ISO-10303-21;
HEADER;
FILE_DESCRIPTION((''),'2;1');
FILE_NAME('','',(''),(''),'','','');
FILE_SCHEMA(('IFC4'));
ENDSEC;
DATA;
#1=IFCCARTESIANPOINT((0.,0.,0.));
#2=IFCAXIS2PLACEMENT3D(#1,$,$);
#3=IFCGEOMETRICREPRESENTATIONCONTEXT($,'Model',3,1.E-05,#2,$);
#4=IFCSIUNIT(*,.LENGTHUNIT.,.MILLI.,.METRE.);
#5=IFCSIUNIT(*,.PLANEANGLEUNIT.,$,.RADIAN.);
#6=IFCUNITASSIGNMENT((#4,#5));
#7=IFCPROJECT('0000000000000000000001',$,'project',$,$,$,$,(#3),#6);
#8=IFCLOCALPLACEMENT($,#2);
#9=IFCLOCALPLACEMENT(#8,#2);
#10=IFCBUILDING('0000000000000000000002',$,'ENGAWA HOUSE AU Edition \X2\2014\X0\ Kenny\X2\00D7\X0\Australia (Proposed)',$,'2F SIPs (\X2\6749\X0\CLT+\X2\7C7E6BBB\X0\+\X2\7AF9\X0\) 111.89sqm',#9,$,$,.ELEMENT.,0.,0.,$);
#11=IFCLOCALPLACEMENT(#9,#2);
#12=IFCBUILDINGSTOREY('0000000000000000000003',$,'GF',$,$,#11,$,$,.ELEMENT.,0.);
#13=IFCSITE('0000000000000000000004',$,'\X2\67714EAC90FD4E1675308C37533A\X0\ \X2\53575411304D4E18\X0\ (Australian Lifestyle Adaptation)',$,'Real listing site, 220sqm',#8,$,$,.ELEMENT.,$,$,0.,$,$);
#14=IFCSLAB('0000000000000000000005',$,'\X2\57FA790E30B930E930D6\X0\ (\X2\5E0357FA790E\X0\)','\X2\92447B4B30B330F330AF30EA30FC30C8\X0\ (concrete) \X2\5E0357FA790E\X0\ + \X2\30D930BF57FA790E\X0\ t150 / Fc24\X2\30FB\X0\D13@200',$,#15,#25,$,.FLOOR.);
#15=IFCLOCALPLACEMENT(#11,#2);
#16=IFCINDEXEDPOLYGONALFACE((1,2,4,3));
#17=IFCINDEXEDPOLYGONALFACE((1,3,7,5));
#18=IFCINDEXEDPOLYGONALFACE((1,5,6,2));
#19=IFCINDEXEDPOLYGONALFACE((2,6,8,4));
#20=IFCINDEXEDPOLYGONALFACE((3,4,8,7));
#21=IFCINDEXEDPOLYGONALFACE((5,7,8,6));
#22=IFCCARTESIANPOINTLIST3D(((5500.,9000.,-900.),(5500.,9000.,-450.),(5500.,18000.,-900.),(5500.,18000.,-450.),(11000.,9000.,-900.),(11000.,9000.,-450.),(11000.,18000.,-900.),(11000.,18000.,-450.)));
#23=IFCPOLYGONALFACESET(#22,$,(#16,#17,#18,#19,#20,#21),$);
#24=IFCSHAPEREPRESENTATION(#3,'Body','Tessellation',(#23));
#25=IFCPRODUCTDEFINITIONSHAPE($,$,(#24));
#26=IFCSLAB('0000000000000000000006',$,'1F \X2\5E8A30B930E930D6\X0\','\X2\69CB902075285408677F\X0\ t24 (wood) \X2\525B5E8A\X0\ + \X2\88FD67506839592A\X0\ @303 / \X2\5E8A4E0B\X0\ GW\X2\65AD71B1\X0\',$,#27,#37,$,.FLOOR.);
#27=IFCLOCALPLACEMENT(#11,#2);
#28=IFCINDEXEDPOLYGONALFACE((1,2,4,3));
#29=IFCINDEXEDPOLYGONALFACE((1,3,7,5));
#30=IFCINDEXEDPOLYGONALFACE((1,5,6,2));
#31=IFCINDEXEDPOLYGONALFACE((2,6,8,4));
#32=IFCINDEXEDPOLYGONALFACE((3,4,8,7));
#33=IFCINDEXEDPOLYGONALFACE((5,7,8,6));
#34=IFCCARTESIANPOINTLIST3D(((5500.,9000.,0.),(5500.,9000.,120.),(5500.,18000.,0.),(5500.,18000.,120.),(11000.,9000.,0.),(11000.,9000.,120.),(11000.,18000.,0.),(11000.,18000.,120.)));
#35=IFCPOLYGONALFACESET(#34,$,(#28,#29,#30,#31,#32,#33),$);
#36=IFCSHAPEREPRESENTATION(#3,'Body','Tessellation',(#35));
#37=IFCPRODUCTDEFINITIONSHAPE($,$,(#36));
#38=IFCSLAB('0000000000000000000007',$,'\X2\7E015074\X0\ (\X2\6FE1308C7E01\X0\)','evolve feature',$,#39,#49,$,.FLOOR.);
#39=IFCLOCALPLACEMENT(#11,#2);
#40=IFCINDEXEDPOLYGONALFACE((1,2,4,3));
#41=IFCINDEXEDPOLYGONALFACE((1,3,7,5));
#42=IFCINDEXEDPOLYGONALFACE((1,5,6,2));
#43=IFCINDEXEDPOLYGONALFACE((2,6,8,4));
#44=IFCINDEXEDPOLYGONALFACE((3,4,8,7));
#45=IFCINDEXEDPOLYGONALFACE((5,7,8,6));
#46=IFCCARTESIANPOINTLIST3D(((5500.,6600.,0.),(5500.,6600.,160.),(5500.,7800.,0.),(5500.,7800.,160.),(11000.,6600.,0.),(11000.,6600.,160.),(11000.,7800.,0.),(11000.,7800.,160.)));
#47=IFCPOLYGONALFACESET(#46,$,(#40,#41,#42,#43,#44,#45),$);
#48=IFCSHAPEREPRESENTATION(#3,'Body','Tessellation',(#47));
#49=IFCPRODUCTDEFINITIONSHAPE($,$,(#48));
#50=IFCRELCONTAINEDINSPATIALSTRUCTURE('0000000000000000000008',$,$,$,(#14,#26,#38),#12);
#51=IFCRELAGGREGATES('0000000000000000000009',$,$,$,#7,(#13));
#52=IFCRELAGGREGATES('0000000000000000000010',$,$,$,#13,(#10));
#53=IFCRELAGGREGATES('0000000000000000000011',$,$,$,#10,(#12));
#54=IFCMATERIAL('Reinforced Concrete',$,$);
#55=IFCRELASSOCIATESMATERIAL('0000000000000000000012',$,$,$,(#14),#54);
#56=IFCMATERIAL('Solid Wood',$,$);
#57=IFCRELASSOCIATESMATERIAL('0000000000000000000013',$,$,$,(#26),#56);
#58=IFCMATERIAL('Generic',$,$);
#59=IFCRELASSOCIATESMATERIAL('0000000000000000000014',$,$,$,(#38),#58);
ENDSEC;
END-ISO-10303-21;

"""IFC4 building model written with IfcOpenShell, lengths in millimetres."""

from ifc_helpers import new_model, si_unit, frame, frame_2d, origin, place, context, project, spatial, rectangle, extrude, material, element, save


model = new_model("IFC4")

# Units and contexts
model_context = context("Model", 3, precision=1e-05, world=origin())
ifc_project = project(units=[si_unit("LENGTHUNIT", "METRE", prefix="MILLI"), si_unit("PLANEANGLEUNIT", "RADIAN")], contexts=[model_context])

# Site, building, storey
site_placement = place(None, origin())
site = spatial("IfcSite", under=ifc_project, at=site_placement, Name="東京都世田谷区 南向き丘 (Australian Lifestyle Adaptation)", ObjectType="Real listing site, 220sqm", CompositionType="ELEMENT", RefElevation=0.0)
building_placement = place(site_placement, origin())
building = spatial("IfcBuilding", under=site, at=building_placement, Name="ENGAWA HOUSE AU Edition — Kenny×Australia (Proposed)", ObjectType="2F SIPs (杉CLT+籾殻+竹) 111.89sqm", CompositionType="ELEMENT", ElevationOfRefHeight=0.0, ElevationOfTerrain=0.0)
storey_placement = place(building_placement, origin())
storey = spatial("IfcBuildingStorey", under=building, at=storey_placement, Name="GF", CompositionType="ELEMENT", Elevation=0.0)

# Slabs
ifc_material_1 = material(Name="Reinforced Concrete")
slab_1_placement = place(storey_placement, frame((2750.0, 4500.0, -450.0)))
element("IfcSlab", 1, at=slab_1_placement, inside=storey, material=ifc_material_1, Name="基礎スラブ (布基礎)", Description="鉄筋コンクリート (concrete) 布基礎 + ベタ基礎 t150 / Fc24・D13@200", PredefinedType="FLOOR", context=model_context, shape_type="SweptSolid", body=[
    extrude(rectangle(XDim=5500.0, YDim=9000.0, at=frame_2d((2750.0, 4500.0))), frame((2750.0, 4500.0, -450.0)), (0.0, 0.0, 1.0), 450.0),
])
ifc_material_2 = material(Name="Solid Wood")
slab_2_placement = place(storey_placement, frame((2750.0, 4500.0, 0.0)))
element("IfcSlab", 2, at=slab_2_placement, inside=storey, material=ifc_material_2, Name="1F 床スラブ", Description="構造用合板 t24 (wood) 剛床 + 製材根太 @303 / 床下 GW断熱", PredefinedType="FLOOR", context=model_context, shape_type="SweptSolid", body=[
    extrude(rectangle(XDim=5500.0, YDim=9000.0, at=frame_2d((2750.0, 4500.0))), frame((2750.0, 4500.0, 0.0)), (0.0, 0.0, 1.0), 120.0),
])
ifc_material_3 = material(Name="Generic")
slab_3_placement = place(storey_placement, frame((2750.0, 3300.0, 0.0)))
element("IfcSlab", 3, at=slab_3_placement, inside=storey, material=ifc_material_3, Name="縁側 (濡れ縁)", Description="evolve feature", PredefinedType="FLOOR", context=model_context, shape_type="SweptSolid", body=[
    extrude(rectangle(XDim=5500.0, YDim=1200.0, at=frame_2d((2750.0, 600.0))), frame((2750.0, 3300.0, 0.0)), (0.0, 0.0, 1.0), 160.0),
])

save(model, "model.ifc")
